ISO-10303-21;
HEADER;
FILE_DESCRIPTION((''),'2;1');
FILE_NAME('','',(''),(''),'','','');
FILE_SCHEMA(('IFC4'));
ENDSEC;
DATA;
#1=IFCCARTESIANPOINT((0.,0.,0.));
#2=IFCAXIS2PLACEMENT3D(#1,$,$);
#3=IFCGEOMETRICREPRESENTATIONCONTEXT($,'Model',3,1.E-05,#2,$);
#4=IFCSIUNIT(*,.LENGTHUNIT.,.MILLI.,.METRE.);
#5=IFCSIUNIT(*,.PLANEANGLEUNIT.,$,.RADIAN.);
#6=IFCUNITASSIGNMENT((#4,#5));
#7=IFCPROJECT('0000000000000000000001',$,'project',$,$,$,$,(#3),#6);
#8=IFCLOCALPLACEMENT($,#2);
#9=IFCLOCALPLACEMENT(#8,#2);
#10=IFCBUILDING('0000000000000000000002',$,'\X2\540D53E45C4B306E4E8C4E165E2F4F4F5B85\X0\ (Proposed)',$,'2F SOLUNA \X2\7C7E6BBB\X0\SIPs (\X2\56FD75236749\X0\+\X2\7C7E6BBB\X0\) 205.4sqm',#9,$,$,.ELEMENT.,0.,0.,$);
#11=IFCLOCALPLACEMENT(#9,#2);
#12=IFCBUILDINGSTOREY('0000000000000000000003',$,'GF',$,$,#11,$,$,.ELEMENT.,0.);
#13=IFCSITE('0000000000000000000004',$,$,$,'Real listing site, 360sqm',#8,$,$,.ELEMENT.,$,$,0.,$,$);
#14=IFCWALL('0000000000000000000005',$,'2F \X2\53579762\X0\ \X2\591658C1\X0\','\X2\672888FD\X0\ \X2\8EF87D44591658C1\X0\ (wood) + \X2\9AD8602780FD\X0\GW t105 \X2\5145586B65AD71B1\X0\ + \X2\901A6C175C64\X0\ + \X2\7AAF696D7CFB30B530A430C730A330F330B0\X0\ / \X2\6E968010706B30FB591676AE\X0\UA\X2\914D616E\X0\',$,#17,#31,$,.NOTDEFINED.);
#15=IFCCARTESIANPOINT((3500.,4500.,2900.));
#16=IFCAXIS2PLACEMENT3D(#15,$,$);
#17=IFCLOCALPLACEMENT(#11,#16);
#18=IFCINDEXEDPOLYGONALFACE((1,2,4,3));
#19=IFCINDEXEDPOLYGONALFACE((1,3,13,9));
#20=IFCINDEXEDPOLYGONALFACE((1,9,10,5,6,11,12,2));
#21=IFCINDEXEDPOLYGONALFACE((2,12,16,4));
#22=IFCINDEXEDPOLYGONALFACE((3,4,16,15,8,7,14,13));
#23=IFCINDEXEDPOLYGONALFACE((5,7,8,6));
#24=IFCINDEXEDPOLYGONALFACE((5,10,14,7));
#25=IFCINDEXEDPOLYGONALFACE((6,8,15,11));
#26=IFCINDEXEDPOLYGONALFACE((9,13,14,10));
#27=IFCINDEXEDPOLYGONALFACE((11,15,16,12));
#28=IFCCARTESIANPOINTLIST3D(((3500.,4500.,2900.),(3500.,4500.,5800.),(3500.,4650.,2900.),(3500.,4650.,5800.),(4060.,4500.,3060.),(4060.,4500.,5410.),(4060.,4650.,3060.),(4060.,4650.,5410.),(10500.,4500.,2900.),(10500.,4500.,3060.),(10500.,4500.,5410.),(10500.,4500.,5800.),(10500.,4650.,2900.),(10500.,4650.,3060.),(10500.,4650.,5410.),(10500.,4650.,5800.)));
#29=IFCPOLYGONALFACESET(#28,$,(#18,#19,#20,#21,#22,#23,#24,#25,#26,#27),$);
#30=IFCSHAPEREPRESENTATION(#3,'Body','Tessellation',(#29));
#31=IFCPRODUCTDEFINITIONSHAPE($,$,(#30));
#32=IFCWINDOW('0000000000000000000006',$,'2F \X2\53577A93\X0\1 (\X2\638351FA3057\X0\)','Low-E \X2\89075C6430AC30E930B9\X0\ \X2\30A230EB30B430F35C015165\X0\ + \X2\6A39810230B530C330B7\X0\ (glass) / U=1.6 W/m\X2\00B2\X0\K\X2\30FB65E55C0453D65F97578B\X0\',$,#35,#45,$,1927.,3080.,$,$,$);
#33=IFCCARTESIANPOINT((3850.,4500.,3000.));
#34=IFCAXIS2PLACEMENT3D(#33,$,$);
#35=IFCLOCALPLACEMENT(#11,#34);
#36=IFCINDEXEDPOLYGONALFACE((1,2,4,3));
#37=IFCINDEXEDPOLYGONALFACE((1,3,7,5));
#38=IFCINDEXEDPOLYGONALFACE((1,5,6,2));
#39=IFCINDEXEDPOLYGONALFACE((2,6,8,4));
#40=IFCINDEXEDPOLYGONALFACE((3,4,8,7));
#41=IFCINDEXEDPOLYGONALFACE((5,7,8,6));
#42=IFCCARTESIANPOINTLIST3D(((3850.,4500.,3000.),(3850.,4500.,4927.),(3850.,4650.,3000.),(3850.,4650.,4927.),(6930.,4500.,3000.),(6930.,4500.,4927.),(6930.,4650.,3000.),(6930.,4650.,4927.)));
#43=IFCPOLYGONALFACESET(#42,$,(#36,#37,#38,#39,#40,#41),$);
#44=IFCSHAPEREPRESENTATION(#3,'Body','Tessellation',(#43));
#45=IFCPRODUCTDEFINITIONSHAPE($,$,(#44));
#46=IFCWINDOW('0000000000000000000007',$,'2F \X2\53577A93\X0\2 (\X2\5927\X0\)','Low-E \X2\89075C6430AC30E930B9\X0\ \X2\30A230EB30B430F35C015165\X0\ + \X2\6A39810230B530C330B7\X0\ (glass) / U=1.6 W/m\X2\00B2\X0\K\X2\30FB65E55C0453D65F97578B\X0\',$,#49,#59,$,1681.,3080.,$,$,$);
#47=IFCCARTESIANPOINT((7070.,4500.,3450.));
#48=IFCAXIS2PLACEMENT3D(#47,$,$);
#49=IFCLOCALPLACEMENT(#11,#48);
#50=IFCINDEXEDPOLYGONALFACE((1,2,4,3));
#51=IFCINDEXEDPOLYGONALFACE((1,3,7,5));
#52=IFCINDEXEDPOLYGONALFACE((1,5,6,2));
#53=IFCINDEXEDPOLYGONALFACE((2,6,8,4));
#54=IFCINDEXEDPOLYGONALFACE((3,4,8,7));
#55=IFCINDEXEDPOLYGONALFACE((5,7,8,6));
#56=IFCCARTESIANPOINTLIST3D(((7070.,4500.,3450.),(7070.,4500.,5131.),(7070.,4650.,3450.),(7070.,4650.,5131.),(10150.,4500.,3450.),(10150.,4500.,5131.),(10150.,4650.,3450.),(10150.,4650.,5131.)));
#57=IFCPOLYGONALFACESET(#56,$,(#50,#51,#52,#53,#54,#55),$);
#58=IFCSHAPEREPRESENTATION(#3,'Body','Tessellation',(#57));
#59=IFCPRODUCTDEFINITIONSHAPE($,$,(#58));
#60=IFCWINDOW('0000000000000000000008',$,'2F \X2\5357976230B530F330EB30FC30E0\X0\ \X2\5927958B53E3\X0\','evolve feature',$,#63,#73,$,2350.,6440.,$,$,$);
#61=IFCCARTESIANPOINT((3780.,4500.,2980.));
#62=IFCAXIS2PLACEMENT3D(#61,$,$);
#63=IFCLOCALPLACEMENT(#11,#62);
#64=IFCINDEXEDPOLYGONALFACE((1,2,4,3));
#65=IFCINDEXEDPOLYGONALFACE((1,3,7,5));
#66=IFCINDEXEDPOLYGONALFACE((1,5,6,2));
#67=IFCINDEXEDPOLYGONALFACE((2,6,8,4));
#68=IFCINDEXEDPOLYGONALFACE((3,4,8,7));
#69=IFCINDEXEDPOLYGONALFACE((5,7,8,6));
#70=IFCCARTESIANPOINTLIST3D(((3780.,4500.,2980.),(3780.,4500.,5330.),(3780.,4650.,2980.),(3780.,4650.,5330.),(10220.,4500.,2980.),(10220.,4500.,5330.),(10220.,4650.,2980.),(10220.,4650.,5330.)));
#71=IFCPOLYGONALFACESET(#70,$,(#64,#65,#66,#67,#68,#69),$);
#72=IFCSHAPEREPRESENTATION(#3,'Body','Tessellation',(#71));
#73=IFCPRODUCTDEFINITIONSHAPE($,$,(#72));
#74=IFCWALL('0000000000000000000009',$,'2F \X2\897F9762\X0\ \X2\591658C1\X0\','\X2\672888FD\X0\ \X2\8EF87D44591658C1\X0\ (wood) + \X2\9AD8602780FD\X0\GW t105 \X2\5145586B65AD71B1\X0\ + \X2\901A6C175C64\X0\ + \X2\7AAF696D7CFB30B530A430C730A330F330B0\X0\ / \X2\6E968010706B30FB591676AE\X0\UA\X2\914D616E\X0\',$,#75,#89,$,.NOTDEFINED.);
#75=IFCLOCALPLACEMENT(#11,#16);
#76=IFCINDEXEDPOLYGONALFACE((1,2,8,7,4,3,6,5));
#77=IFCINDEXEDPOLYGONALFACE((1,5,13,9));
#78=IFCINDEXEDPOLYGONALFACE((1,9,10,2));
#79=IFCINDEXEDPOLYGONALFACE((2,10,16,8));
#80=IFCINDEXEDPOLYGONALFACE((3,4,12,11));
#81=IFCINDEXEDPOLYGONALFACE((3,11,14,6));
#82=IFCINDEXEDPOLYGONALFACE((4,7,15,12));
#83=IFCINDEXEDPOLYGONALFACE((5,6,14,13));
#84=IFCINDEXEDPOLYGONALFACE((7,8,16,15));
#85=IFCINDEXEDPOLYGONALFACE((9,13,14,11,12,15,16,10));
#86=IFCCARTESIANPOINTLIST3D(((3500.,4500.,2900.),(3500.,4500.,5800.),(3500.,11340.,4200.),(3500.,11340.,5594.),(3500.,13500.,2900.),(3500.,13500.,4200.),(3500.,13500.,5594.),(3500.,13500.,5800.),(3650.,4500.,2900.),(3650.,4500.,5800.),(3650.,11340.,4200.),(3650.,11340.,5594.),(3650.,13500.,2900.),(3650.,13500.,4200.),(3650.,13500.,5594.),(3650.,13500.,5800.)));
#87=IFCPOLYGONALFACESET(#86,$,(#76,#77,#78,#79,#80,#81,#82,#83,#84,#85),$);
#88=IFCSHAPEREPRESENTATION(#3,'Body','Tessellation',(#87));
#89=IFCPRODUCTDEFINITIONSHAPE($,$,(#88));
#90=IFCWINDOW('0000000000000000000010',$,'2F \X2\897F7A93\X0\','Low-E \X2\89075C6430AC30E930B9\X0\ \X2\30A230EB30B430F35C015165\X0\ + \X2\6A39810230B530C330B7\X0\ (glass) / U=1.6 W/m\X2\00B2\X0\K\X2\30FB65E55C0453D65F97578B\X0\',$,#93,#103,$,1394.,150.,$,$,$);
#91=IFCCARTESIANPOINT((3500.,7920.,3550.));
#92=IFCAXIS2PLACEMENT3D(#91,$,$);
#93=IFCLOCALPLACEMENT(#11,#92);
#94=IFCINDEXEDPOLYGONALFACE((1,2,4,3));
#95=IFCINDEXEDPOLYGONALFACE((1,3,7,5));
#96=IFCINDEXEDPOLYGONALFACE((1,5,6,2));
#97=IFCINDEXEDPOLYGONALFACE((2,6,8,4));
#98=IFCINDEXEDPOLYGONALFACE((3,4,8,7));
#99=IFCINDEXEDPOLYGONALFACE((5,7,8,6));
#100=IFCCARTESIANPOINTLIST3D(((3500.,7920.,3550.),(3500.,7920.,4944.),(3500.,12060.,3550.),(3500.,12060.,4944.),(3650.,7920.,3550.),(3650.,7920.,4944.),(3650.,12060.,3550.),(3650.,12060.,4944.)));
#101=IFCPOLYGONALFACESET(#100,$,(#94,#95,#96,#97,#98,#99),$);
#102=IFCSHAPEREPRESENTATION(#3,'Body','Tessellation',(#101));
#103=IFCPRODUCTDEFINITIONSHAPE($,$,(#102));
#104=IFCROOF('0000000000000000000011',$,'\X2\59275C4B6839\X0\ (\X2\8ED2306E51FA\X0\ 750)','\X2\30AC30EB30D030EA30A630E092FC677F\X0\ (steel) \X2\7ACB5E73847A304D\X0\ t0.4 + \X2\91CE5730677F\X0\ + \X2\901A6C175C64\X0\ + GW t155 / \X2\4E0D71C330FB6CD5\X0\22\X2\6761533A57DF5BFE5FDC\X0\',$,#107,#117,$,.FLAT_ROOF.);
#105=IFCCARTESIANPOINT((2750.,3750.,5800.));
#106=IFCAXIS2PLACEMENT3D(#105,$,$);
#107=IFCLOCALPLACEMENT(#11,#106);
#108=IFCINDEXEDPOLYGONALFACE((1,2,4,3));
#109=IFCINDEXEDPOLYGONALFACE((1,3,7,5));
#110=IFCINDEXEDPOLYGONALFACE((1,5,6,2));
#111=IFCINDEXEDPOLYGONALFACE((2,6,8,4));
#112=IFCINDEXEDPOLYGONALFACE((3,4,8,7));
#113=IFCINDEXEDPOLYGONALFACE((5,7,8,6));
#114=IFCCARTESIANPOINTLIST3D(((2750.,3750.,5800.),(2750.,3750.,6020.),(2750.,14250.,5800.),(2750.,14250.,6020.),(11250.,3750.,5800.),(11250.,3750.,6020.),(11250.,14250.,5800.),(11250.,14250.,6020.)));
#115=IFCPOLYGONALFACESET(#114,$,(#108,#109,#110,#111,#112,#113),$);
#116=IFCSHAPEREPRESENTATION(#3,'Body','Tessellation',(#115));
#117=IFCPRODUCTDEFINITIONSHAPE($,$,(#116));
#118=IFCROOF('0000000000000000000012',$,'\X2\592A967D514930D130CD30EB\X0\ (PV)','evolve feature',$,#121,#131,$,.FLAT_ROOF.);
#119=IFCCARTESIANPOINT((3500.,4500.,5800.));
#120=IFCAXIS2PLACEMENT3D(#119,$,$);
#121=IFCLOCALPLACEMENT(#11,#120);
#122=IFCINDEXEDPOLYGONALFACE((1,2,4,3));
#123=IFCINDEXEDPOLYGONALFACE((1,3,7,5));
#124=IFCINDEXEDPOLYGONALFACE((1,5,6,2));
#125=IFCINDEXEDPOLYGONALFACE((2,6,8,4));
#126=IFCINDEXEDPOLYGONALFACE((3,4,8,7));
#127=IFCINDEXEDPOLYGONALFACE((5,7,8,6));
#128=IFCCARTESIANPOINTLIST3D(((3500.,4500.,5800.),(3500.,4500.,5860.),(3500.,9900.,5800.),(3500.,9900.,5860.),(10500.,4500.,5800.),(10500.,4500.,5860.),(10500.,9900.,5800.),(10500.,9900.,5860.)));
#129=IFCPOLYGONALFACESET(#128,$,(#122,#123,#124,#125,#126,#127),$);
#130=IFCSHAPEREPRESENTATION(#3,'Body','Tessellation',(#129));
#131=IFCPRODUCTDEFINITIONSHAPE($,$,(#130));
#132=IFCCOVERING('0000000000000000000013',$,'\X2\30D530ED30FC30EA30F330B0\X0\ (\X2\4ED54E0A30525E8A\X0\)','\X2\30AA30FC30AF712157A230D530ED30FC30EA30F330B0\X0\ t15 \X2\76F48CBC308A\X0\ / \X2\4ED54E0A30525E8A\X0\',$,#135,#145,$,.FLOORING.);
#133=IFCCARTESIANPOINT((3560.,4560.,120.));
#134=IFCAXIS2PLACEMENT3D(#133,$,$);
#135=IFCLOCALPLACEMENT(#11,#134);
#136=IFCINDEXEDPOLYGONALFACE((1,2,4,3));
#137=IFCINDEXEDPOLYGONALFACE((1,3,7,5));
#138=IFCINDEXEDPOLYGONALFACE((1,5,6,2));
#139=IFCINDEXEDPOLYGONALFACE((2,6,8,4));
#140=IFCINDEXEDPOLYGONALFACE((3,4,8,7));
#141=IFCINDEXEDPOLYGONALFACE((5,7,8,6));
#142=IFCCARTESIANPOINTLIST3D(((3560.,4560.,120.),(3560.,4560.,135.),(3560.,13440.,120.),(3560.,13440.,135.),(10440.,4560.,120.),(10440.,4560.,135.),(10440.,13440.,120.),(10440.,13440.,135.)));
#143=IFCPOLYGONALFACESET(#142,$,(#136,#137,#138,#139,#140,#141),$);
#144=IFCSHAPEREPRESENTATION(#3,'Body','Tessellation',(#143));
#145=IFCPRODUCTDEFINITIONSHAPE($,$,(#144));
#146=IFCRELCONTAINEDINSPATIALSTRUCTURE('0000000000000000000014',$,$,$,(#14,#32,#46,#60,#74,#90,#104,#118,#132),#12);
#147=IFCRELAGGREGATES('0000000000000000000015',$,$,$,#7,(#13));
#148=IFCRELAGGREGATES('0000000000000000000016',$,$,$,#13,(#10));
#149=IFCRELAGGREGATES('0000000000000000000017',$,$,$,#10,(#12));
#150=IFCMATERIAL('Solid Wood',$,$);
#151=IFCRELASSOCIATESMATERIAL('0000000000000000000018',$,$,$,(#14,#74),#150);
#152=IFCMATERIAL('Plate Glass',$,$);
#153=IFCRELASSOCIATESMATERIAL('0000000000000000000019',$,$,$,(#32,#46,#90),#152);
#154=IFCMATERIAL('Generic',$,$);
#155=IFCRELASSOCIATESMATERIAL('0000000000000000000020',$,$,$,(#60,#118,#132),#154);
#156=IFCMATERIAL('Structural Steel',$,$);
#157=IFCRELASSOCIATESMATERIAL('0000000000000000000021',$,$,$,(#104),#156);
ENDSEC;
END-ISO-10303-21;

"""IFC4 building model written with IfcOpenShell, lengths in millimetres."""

from ifc_helpers import new_model, si_unit, frame, frame_2d, origin, place, context, project, spatial, rectangle, extrude, material, element, fill, save


model = new_model("IFC4")

# Units and contexts
model_context = context("Model", 3, precision=1e-05, world=origin())
ifc_project = project(units=[si_unit("LENGTHUNIT", "METRE", prefix="MILLI"), si_unit("PLANEANGLEUNIT", "RADIAN")], contexts=[model_context])

# Site, building, storey
site_placement = place(None, origin())
site = spatial("IfcSite", under=ifc_project, at=site_placement, ObjectType="Real listing site, 360sqm", CompositionType="ELEMENT", RefElevation=0.0)
building_placement = place(site_placement, origin())
building = spatial("IfcBuilding", under=site, at=building_placement, Name="名古屋の二世帯住宅 (Proposed)", ObjectType="2F SOLUNA 籾殻SIPs (国産杉+籾殻) 205.4sqm", CompositionType="ELEMENT", ElevationOfRefHeight=0.0, ElevationOfTerrain=0.0)
storey_placement = place(building_placement, origin())
storey = spatial("IfcBuildingStorey", under=building, at=storey_placement, Name="GF", CompositionType="ELEMENT", Elevation=0.0)

# Shared definitions
ifc_material_1 = material(Name="Solid Wood")

# Shared definitions
ifc_material_2 = material(Name="Plate Glass")
ifc_material_3 = material(Name="Generic")

# Wall, openings, windows
wall_1_placement = place(storey_placement, frame((3500.0, 4500.0, 2900.0)))
wall_1 = element("IfcWall", 1, at=wall_1_placement, inside=storey, material=ifc_material_1, Name="2F 南面 外壁", Description="木製 軸組外壁 (wood) + 高性能GW t105 充填断熱 + 通気層 + 窯業系サイディング / 準耐火・外皮UA配慮", PredefinedType="NOTDEFINED", context=model_context, shape_type="SweptSolid", body=[
    extrude(rectangle(XDim=7000.0, YDim=150.0, at=frame_2d((3500.0, 75.0))), frame((3500.0, 4500.0, 2900.0)), (0.0, 0.0, 1.0), 2900.0),
])
opening_1_placement = place(storey_placement, frame((3850.0, 4500.0, 3000.0)))
opening_1 = element("IfcOpeningElement", 2, at=opening_1_placement, cuts=wall_1, PredefinedType="NOTDEFINED", context=model_context, shape_type="SweptSolid", body=[
    extrude(rectangle(XDim=3080.0, YDim=150.0, at=frame_2d((1540.0, 75.0))), frame((3850.0, 4500.0, 3000.0)), (0.0, 0.0, 1.0), 1927.0),
])
opening_2_placement = place(storey_placement, frame((7070.0, 4500.0, 3450.0)))
opening_2 = element("IfcOpeningElement", 3, at=opening_2_placement, cuts=wall_1, PredefinedType="NOTDEFINED", context=model_context, shape_type="SweptSolid", body=[
    extrude(rectangle(XDim=3080.0, YDim=150.0, at=frame_2d((1540.0, 75.0))), frame((7070.0, 4500.0, 3450.0)), (0.0, 0.0, 1.0), 1681.0),
])
opening_3_placement = place(storey_placement, frame((3780.0, 4500.0, 2980.0)))
opening_3 = element("IfcOpeningElement", 4, at=opening_3_placement, cuts=wall_1, PredefinedType="NOTDEFINED", context=model_context, shape_type="SweptSolid", body=[
    extrude(rectangle(XDim=6440.0, YDim=150.0, at=frame_2d((3220.0, 75.0))), frame((3780.0, 4500.0, 2980.0)), (0.0, 0.0, 1.0), 2350.0),
])
window_1_placement = place(storey_placement, frame((3850.0, 4500.0, 3000.0)))
window_1 = element("IfcWindow", 5, at=window_1_placement, inside=storey, material=ifc_material_2, Name="2F 南窓1 (掃出し)", Description="Low-E 複層ガラス アルゴン封入 + 樹脂サッシ (glass) / U=1.6 W/m²K・日射取得型", OverallHeight=1927.0, OverallWidth=3080.0, context=model_context, shape_type="SweptSolid", body=[
    extrude(rectangle(XDim=3080.0, YDim=150.0, at=frame_2d((1540.0, 75.0))), frame((3850.0, 4500.0, 3000.0)), (0.0, 0.0, 1.0), 1927.0),
])
fill(opening_1, window_1)
window_2_placement = place(storey_placement, frame((7070.0, 4500.0, 3450.0)))
window_2 = element("IfcWindow", 6, at=window_2_placement, inside=storey, material=ifc_material_2, Name="2F 南窓2 (大)", Description="Low-E 複層ガラス アルゴン封入 + 樹脂サッシ (glass) / U=1.6 W/m²K・日射取得型", OverallHeight=1681.0, OverallWidth=3080.0, context=model_context, shape_type="SweptSolid", body=[
    extrude(rectangle(XDim=3080.0, YDim=150.0, at=frame_2d((1540.0, 75.0))), frame((7070.0, 4500.0, 3450.0)), (0.0, 0.0, 1.0), 1681.0),
])
fill(opening_2, window_2)
window_3_placement = place(storey_placement, frame((3780.0, 4500.0, 2980.0)))
window_3 = element("IfcWindow", 7, at=window_3_placement, inside=storey, material=ifc_material_3, Name="2F 南面サンルーム 大開口", Description="evolve feature", OverallHeight=2350.0, OverallWidth=6440.0, context=model_context, shape_type="SweptSolid", body=[
    extrude(rectangle(XDim=6440.0, YDim=150.0, at=frame_2d((3220.0, 75.0))), frame((3780.0, 4500.0, 2980.0)), (0.0, 0.0, 1.0), 2350.0),
])
fill(opening_3, window_3)

# Wall, opening, window
wall_2_placement = place(storey_placement, frame((3500.0, 4500.0, 2900.0)))
wall_2 = element("IfcWall", 8, at=wall_2_placement, inside=storey, material=ifc_material_1, Name="2F 西面 外壁", Description="木製 軸組外壁 (wood) + 高性能GW t105 充填断熱 + 通気層 + 窯業系サイディング / 準耐火・外皮UA配慮", PredefinedType="NOTDEFINED", context=model_context, shape_type="SweptSolid", body=[
    extrude(rectangle(XDim=150.0, YDim=9000.0, at=frame_2d((75.0, 4500.0))), frame((3500.0, 4500.0, 2900.0)), (0.0, 0.0, 1.0), 2900.0),
])
opening_4_placement = place(storey_placement, frame((3500.0, 7920.0, 3550.0)))
opening_4 = element("IfcOpeningElement", 9, at=opening_4_placement, cuts=wall_2, PredefinedType="NOTDEFINED", context=model_context, shape_type="SweptSolid", body=[
    extrude(rectangle(XDim=150.0, YDim=4140.0, at=frame_2d((75.0, 2070.0))), frame((3500.0, 7920.0, 3550.0)), (0.0, 0.0, 1.0), 1394.0),
])
window_4_placement = place(storey_placement, frame((3500.0, 7920.0, 3550.0)))
window_4 = element("IfcWindow", 10, at=window_4_placement, inside=storey, material=ifc_material_2, Name="2F 西窓", Description="Low-E 複層ガラス アルゴン封入 + 樹脂サッシ (glass) / U=1.6 W/m²K・日射取得型", OverallHeight=1394.0, OverallWidth=150.0, context=model_context, shape_type="SweptSolid", body=[
    extrude(rectangle(XDim=150.0, YDim=4140.0, at=frame_2d((75.0, 2070.0))), frame((3500.0, 7920.0, 3550.0)), (0.0, 0.0, 1.0), 1394.0),
])
fill(opening_4, window_4)

# Roofs
ifc_material_4 = material(Name="Structural Steel")
roof_1_placement = place(storey_placement, frame((2750.0, 3750.0, 5800.0)))
element("IfcRoof", 11, at=roof_1_placement, inside=storey, material=ifc_material_4, Name="大屋根 (軒の出 750)", Description="ガルバリウム鋼板 (steel) 立平葺き t0.4 + 野地板 + 通気層 + GW t155 / 不燃・法22条区域対応", PredefinedType="FLAT_ROOF", context=model_context, shape_type="SweptSolid", body=[
    extrude(rectangle(XDim=8500.0, YDim=10500.0, at=frame_2d((4250.0, 5250.0))), frame((2750.0, 3750.0, 5800.0)), (0.0, 0.0, 1.0), 220.0),
])
roof_2_placement = place(storey_placement, frame((3500.0, 4500.0, 5800.0)))
element("IfcRoof", 12, at=roof_2_placement, inside=storey, material=ifc_material_3, Name="太陽光パネル (PV)", Description="evolve feature", PredefinedType="FLAT_ROOF", context=model_context, shape_type="SweptSolid", body=[
    extrude(rectangle(XDim=7000.0, YDim=5400.0, at=frame_2d((3500.0, 2700.0))), frame((3500.0, 4500.0, 5800.0)), (0.0, 0.0, 1.0), 60.0),
])

# Covering
covering_placement = place(storey_placement, frame((3560.0, 4560.0, 120.0)))
element("IfcCovering", 13, at=covering_placement, inside=storey, material=ifc_material_3, Name="フローリング (仕上げ床)", Description="オーク無垢フローリング t15 直貼り / 仕上げ床", PredefinedType="FLOORING", context=model_context, shape_type="SweptSolid", body=[
    extrude(rectangle(XDim=6880.0, YDim=8880.0, at=frame_2d((3440.0, 4440.0))), frame((3560.0, 4560.0, 120.0)), (0.0, 0.0, 1.0), 15.0),
])

save(model, "model.ifc")
